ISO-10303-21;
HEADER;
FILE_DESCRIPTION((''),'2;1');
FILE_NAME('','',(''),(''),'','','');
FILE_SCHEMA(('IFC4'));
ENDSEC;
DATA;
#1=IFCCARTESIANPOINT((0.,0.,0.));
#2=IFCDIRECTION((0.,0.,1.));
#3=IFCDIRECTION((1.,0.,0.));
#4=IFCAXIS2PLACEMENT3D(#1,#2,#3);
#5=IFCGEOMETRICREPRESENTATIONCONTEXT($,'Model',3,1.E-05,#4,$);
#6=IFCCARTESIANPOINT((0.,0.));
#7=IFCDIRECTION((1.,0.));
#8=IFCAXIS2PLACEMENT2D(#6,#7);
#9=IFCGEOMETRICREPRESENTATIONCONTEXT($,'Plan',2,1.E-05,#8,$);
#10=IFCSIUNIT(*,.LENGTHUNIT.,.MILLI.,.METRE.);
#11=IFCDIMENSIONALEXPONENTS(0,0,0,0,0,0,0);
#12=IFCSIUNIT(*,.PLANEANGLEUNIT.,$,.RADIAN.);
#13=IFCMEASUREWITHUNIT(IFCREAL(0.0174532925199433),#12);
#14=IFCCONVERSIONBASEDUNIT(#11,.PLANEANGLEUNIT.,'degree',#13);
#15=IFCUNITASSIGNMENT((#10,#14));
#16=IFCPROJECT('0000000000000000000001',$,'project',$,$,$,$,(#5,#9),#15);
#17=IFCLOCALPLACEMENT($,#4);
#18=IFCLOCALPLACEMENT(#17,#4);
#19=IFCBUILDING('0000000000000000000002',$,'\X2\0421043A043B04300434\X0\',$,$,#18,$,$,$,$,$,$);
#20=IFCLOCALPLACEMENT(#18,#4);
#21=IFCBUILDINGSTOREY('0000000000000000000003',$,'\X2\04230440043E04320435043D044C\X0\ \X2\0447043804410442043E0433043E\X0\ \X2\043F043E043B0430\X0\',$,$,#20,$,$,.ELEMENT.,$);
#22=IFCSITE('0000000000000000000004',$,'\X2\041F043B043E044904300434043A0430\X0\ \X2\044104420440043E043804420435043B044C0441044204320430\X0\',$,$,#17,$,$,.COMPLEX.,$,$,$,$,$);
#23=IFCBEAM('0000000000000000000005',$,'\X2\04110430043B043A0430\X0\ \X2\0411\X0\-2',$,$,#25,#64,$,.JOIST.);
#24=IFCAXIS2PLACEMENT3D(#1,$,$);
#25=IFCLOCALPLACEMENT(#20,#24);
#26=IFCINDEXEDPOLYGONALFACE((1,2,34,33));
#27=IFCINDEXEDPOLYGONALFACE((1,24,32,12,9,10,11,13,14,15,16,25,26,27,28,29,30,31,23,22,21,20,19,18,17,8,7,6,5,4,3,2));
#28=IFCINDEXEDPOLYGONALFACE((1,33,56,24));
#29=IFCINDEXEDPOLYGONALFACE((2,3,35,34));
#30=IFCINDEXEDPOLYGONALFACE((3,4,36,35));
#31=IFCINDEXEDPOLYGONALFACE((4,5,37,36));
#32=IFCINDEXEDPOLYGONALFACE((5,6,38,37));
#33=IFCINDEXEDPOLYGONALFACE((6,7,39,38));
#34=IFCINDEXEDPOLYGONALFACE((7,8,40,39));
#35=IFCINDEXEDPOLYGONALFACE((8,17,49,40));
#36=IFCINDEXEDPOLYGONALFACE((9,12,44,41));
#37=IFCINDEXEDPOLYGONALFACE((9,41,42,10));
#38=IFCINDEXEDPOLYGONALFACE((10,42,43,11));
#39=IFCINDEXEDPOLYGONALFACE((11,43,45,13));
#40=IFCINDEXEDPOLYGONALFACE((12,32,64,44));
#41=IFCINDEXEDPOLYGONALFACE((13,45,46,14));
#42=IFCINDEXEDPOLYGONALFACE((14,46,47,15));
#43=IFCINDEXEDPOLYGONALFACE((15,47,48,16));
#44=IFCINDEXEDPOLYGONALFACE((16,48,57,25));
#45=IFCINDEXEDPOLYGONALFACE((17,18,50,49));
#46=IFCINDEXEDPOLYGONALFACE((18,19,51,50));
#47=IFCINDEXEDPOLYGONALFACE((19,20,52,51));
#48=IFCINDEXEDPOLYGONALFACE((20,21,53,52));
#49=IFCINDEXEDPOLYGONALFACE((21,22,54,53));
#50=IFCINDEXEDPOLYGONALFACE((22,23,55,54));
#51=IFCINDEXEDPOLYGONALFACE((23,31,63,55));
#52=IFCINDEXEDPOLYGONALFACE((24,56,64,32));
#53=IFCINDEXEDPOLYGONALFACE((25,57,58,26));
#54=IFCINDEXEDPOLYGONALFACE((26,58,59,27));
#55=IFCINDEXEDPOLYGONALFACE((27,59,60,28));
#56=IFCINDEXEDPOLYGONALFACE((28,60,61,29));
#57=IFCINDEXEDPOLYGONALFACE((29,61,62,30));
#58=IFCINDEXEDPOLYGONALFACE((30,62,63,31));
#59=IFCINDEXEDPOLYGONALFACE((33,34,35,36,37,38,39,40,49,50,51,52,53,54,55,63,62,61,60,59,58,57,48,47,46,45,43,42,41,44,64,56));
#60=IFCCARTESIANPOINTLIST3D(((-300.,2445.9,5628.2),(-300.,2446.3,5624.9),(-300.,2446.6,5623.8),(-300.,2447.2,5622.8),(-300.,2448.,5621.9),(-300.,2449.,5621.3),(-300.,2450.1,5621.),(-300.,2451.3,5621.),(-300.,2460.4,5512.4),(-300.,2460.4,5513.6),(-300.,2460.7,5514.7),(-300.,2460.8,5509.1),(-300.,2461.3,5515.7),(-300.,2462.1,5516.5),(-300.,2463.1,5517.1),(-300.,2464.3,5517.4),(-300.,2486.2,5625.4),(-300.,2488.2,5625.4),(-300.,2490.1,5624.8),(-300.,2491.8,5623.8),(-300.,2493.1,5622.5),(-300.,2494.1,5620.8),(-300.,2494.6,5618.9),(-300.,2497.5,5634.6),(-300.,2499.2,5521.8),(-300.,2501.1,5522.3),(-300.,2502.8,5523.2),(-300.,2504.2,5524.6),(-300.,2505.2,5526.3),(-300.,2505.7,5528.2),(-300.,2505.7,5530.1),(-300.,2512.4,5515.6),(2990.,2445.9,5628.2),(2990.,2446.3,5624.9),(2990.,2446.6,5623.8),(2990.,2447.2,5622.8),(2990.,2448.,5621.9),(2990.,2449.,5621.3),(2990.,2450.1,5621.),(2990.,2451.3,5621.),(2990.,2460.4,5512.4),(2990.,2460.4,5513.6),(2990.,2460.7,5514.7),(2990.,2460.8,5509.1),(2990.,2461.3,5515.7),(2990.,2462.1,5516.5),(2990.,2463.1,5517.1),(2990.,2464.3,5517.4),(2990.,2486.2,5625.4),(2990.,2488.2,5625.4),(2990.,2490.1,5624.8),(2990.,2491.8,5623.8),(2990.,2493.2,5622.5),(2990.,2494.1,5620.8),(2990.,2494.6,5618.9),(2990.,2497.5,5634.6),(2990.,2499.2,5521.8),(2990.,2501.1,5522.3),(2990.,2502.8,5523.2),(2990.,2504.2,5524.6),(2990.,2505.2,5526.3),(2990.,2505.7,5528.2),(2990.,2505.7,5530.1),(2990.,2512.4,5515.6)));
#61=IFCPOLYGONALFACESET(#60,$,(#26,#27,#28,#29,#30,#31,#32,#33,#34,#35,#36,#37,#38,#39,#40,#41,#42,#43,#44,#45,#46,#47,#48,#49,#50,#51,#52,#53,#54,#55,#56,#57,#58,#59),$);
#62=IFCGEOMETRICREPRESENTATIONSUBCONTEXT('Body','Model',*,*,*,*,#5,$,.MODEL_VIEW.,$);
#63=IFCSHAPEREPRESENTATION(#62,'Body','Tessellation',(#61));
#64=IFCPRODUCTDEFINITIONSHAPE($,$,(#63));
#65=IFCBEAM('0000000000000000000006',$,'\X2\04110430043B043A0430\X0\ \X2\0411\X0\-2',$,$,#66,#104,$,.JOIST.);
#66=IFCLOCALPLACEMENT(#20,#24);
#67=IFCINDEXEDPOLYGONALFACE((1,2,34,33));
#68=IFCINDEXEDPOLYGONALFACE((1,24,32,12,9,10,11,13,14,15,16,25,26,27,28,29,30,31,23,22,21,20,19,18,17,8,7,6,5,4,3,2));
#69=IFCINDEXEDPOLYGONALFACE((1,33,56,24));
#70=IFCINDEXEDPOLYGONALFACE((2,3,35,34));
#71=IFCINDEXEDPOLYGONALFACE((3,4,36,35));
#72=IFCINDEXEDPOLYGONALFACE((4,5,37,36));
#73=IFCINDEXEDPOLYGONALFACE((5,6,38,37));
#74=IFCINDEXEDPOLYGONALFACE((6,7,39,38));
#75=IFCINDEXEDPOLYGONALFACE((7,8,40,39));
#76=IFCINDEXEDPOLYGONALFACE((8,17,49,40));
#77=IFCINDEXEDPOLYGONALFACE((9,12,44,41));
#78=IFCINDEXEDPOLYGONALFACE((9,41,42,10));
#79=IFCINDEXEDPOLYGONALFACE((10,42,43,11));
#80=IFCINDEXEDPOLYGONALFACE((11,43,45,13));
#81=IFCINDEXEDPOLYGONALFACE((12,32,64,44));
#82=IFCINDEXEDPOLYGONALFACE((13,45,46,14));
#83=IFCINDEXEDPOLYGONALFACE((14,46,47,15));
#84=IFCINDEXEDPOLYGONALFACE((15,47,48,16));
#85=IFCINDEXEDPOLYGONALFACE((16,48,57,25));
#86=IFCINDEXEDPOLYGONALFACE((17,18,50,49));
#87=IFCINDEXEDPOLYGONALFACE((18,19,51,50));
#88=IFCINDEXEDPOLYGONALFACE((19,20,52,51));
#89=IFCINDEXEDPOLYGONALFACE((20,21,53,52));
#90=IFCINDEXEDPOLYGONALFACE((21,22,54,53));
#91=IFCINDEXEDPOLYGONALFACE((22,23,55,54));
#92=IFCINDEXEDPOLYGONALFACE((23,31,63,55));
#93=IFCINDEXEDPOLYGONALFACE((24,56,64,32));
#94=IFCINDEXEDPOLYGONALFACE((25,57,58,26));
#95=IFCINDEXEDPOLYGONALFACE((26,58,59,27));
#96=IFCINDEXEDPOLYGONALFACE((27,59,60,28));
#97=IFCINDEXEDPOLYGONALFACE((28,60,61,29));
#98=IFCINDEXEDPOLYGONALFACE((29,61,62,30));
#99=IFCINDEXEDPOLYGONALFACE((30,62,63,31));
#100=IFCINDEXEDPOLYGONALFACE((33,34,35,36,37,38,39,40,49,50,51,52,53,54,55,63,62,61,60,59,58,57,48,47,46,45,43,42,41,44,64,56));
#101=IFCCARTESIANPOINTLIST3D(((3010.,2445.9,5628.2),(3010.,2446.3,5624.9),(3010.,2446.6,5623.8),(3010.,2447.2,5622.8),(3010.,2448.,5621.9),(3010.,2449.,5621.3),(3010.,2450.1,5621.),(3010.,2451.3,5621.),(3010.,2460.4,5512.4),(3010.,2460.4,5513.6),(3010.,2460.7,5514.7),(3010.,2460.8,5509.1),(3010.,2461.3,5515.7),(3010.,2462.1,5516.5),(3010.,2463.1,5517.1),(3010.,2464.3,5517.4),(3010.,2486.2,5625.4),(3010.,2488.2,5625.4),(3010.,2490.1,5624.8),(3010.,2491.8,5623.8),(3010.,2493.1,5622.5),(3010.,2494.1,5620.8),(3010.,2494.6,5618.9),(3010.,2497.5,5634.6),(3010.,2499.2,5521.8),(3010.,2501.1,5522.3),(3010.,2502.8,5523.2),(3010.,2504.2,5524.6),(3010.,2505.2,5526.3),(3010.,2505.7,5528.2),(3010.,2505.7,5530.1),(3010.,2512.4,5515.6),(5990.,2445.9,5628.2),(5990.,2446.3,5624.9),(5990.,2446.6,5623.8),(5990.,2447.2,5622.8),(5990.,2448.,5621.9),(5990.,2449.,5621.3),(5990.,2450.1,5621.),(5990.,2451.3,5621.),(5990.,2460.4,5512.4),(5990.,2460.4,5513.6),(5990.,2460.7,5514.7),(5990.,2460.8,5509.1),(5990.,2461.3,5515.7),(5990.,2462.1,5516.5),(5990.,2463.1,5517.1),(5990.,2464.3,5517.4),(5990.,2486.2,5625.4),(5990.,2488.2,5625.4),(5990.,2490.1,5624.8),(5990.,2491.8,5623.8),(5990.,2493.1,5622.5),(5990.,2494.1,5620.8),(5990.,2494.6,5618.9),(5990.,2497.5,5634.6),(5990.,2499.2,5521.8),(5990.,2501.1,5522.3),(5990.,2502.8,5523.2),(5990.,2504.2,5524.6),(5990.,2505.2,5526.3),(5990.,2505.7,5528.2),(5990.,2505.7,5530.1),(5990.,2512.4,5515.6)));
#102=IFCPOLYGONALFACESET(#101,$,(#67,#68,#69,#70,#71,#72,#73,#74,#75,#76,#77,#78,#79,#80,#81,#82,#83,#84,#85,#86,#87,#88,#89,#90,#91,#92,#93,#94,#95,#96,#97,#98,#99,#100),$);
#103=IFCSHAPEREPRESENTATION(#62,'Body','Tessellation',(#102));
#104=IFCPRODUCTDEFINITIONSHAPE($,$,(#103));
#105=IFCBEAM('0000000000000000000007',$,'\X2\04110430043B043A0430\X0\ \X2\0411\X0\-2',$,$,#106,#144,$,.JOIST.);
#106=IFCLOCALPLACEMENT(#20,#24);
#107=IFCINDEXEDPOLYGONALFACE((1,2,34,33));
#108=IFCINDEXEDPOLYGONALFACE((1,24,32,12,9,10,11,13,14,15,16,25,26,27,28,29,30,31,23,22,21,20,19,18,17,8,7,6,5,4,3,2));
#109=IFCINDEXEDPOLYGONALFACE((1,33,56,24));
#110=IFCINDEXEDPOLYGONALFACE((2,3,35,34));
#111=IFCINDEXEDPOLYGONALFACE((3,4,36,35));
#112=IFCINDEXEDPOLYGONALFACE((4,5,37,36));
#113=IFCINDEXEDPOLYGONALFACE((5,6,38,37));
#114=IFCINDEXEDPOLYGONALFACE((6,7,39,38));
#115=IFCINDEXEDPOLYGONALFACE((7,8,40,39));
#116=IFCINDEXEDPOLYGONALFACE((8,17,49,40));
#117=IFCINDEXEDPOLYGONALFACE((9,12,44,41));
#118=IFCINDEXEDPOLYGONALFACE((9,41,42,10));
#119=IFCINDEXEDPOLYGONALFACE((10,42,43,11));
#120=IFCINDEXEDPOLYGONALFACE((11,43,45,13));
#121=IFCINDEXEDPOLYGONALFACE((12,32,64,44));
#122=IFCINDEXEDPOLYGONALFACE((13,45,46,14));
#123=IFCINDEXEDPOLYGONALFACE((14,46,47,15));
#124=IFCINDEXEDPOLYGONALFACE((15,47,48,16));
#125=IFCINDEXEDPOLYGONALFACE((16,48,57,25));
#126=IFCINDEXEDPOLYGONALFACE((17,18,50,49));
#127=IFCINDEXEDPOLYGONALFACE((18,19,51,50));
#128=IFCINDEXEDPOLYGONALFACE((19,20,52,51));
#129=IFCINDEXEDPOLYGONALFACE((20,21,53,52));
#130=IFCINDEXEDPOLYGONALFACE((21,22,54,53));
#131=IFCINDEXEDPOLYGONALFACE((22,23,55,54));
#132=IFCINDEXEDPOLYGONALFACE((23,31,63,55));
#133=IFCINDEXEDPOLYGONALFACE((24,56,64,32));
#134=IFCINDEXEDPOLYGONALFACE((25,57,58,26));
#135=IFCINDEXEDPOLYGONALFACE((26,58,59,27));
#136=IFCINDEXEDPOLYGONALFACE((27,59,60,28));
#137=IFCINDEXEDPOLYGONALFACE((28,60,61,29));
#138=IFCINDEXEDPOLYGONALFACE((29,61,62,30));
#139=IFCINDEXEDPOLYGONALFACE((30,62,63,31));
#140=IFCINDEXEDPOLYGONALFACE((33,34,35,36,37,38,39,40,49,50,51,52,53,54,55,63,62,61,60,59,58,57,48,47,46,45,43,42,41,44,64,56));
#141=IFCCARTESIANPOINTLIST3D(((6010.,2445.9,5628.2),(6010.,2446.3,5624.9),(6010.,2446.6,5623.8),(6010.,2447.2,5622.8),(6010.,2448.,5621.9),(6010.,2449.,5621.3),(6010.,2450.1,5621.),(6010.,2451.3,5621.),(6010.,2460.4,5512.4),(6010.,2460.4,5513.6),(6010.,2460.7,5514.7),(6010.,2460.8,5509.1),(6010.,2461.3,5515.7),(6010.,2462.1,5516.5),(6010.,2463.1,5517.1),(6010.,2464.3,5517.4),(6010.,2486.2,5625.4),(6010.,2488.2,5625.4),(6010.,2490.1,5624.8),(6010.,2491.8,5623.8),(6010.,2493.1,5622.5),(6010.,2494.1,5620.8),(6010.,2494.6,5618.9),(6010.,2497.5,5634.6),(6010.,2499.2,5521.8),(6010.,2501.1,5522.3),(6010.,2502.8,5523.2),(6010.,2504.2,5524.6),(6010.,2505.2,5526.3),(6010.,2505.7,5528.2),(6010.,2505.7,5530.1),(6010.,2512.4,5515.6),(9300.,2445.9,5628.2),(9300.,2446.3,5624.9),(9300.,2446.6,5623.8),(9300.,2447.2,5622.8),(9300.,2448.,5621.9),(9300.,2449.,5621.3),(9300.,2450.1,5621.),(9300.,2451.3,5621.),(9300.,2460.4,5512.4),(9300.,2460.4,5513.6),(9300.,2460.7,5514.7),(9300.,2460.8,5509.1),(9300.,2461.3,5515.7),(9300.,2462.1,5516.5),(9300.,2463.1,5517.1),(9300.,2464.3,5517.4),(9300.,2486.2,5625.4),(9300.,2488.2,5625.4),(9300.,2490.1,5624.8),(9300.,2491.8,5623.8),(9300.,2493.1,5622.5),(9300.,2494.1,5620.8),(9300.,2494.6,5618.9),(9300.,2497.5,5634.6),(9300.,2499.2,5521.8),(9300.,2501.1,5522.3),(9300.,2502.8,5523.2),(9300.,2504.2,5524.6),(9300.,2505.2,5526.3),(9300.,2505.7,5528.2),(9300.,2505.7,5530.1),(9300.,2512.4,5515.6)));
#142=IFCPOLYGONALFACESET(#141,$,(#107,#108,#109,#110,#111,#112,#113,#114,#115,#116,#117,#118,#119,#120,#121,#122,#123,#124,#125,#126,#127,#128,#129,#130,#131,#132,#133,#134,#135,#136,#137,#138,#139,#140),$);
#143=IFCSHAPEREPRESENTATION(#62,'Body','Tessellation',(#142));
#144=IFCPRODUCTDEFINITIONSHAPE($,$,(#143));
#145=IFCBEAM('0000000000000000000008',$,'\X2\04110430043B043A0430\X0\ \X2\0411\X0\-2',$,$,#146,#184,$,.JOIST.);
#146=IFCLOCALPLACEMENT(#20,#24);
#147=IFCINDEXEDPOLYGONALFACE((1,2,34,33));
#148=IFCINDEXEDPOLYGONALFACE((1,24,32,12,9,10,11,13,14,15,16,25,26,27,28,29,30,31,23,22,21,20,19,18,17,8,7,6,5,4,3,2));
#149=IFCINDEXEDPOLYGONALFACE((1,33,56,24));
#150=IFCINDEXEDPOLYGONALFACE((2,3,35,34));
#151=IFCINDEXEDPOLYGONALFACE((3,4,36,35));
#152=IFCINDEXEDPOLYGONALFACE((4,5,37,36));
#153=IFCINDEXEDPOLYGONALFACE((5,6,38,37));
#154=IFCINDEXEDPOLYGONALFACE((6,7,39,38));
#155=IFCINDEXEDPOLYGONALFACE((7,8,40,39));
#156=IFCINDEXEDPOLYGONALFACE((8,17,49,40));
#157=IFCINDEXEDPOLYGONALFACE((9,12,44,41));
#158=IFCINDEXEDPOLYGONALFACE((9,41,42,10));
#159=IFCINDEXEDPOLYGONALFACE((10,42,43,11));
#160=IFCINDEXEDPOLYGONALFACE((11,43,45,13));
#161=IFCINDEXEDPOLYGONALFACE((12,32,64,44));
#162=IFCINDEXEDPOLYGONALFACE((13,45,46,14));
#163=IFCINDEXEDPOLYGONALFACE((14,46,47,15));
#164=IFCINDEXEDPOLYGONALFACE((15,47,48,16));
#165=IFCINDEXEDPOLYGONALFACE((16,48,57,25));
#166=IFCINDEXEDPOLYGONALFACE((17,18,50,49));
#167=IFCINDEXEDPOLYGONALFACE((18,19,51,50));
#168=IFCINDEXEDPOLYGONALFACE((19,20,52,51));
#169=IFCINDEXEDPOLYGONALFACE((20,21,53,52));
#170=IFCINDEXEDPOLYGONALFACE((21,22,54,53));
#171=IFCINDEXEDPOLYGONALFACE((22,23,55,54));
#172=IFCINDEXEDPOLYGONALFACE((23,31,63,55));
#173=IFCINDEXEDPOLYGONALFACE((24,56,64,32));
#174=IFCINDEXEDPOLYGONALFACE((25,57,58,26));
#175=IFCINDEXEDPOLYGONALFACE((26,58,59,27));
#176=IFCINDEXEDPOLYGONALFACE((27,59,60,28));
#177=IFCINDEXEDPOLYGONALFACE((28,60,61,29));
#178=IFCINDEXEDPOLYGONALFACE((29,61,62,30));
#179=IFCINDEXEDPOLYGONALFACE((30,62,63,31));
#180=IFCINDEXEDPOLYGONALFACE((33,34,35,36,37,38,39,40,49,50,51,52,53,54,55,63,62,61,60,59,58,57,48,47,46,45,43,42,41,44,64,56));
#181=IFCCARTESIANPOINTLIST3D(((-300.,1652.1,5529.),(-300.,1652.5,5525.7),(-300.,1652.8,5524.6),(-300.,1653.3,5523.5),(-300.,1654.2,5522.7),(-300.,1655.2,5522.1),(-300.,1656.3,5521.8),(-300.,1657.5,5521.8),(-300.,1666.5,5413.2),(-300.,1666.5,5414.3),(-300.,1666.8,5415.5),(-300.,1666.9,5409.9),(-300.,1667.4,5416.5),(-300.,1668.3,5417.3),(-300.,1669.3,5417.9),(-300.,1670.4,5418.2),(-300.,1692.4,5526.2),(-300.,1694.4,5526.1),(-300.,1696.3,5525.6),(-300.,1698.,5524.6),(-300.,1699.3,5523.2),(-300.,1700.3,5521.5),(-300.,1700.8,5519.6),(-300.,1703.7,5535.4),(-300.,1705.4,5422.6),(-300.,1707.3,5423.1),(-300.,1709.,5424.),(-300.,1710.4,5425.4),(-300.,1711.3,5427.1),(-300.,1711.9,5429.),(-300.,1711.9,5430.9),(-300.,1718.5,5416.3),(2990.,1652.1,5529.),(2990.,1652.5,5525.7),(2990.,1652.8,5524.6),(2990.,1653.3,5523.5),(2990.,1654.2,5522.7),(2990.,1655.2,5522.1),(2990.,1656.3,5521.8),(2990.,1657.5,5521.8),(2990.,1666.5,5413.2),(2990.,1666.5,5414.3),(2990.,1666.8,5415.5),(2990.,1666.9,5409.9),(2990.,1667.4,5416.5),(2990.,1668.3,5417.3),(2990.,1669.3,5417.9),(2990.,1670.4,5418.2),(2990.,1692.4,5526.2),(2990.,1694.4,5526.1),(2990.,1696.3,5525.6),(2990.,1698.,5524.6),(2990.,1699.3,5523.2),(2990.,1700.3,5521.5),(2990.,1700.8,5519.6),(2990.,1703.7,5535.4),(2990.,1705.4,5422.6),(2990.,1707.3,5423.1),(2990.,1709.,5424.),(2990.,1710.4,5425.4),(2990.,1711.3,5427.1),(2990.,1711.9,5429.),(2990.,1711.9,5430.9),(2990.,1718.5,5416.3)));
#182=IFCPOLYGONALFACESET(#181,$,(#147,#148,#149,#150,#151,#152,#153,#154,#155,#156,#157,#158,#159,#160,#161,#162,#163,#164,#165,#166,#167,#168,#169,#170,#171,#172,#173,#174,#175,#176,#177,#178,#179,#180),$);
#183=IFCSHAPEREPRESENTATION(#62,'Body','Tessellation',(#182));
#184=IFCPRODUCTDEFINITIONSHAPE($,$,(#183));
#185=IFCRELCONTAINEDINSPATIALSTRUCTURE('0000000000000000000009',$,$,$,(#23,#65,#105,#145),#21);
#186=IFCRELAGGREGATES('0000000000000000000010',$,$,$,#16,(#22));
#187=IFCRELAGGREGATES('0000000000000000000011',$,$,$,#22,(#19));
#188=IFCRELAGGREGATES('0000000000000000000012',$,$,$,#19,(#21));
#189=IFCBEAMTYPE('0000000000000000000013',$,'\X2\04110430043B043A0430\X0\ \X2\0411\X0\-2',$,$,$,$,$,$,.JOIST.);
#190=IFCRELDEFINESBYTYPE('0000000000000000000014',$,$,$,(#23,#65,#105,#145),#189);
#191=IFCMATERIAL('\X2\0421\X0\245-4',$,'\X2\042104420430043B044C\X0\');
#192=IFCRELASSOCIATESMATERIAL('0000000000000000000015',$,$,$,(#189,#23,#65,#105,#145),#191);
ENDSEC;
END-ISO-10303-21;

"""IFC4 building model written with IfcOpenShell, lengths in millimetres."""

from ifc_helpers import new_model, entity, si_unit, converted_unit, frame, origin_with_axes, origin_2d_with_axis, place, context, subcontext, project, spatial, u_section, extrude, material, material_profile, profile_set, profile_usage, type_object, element, save


model = new_model("IFC4")

# Units and contexts
model_context = context("Model", 3, precision=1e-05, world=origin_with_axes())
plan_context = context("Plan", 2, precision=1e-05, world=origin_2d_with_axis())
body_context = subcontext(model_context, "Body", "Model", "MODEL_VIEW")
ifc_project = project(units=[si_unit("LENGTHUNIT", "METRE", prefix="MILLI"), converted_unit("PLANEANGLEUNIT", "degree", entity("IfcReal", 0.0174532925199433), si_unit("PLANEANGLEUNIT", "RADIAN"), dimensions=[0, 0, 0, 0, 0, 0, 0])], contexts=[model_context, plan_context])

# Site, building, storey
site_placement = place(None, origin_with_axes())
site = spatial("IfcSite", under=ifc_project, at=site_placement, Name="Площадка строительства", CompositionType="COMPLEX")
building_placement = place(site_placement, origin_with_axes())
building = spatial("IfcBuilding", under=site, at=building_placement, Name="Склад")
storey_placement = place(building_placement, origin_with_axes())
storey = spatial("IfcBuildingStorey", under=building, at=storey_placement, Name="Уровень чистого пола", CompositionType="ELEMENT")

# Beams
ifc_material_1 = material(Name="С245-4", Category="Сталь")
ifc_material_profile_1 = material_profile(ifc_material_1, u_section(Depth=120.0, FlangeWidth=52.0, WebThickness=4.8, FlangeThickness=7.8, FilletRadius=7.5, EdgeRadius=4.5, FlangeSlope=0.0))
ifc_profile_set_1 = profile_set([ifc_material_profile_1], Name="U12P_S245-4")
beam_type_1 = type_object("IfcBeamType", Name="Балка Б-2", PredefinedType="JOIST", material=ifc_profile_set_1)
ifc_profile_usage_1 = profile_usage(ifc_profile_set_1, cardinal=3)
beam_1_placement = place(storey_placement, frame((2990.0, 2512.4, 5515.6), z_axis=(-1.0, 0.0, 0.0), x_axis=(0.0, -0.99228, -0.124019)))
element("IfcBeam", 1, at=beam_1_placement, inside=storey, type_object=beam_type_1, material=ifc_profile_usage_1, Name="Балка Б-2", PredefinedType="JOIST", context=body_context, shape_type="SweptSolid", body=[
    extrude(u_section(Depth=120.0, FlangeWidth=52.0, WebThickness=4.8, FlangeThickness=7.8, FilletRadius=7.5, EdgeRadius=4.5, FlangeSlope=0.0), frame((26.0, 60.0, 0.0), z_axis=(0.0, 0.0, 1.0), x_axis=(1.0, 0.0, 0.0)), (0.0, 0.0, 1.0), 3290.0),
])
ifc_profile_usage_2 = profile_usage(ifc_profile_set_1, cardinal=3)
beam_2_placement = place(storey_placement, frame((5990.0, 2512.4, 5515.6), z_axis=(-1.0, 0.0, 0.0), x_axis=(0.0, -0.99228, -0.12402)))
element("IfcBeam", 2, at=beam_2_placement, inside=storey, type_object=beam_type_1, material=ifc_profile_usage_2, Name="Балка Б-2", PredefinedType="JOIST", context=body_context, shape_type="SweptSolid", body=[
    extrude(u_section(Depth=120.0, FlangeWidth=52.0, WebThickness=4.8, FlangeThickness=7.8, FilletRadius=7.5, EdgeRadius=4.5, FlangeSlope=0.0), frame((26.0, 60.0, 0.0), z_axis=(0.0, 0.0, 1.0), x_axis=(1.0, 0.0, 0.0)), (0.0, 0.0, 1.0), 2980.0),
])
ifc_profile_usage_3 = profile_usage(ifc_profile_set_1, cardinal=3)
beam_3_placement = place(storey_placement, frame((9300.0, 2512.4, 5515.6), z_axis=(-1.0, 0.0, 0.0), x_axis=(0.0, -0.99228, -0.12402)))
element("IfcBeam", 3, at=beam_3_placement, inside=storey, type_object=beam_type_1, material=ifc_profile_usage_3, Name="Балка Б-2", PredefinedType="JOIST", context=body_context, shape_type="SweptSolid", body=[
    extrude(u_section(Depth=120.0, FlangeWidth=52.0, WebThickness=4.8, FlangeThickness=7.8, FilletRadius=7.5, EdgeRadius=4.5, FlangeSlope=0.0), frame((26.0, 60.0, 0.0), z_axis=(0.0, 0.0, 1.0), x_axis=(1.0, 0.0, 0.0)), (0.0, 0.0, 1.0), 3290.0),
])
ifc_profile_usage_4 = profile_usage(ifc_profile_set_1, cardinal=3)
beam_4_placement = place(storey_placement, frame((2990.0, 1718.5, 5416.3), z_axis=(-1.0, 0.0, 0.0), x_axis=(0.0, -0.99228, -0.124019)))
element("IfcBeam", 4, at=beam_4_placement, inside=storey, type_object=beam_type_1, material=ifc_profile_usage_4, Name="Балка Б-2", PredefinedType="JOIST", context=body_context, shape_type="SweptSolid", body=[
    extrude(u_section(Depth=120.0, FlangeWidth=52.0, WebThickness=4.8, FlangeThickness=7.8, FilletRadius=7.5, EdgeRadius=4.5, FlangeSlope=0.0), frame((26.0, 60.0, 0.0), z_axis=(0.0, 0.0, 1.0), x_axis=(1.0, 0.0, 0.0)), (0.0, 0.0, 1.0), 3290.0),
])

save(model, "model.ifc")
